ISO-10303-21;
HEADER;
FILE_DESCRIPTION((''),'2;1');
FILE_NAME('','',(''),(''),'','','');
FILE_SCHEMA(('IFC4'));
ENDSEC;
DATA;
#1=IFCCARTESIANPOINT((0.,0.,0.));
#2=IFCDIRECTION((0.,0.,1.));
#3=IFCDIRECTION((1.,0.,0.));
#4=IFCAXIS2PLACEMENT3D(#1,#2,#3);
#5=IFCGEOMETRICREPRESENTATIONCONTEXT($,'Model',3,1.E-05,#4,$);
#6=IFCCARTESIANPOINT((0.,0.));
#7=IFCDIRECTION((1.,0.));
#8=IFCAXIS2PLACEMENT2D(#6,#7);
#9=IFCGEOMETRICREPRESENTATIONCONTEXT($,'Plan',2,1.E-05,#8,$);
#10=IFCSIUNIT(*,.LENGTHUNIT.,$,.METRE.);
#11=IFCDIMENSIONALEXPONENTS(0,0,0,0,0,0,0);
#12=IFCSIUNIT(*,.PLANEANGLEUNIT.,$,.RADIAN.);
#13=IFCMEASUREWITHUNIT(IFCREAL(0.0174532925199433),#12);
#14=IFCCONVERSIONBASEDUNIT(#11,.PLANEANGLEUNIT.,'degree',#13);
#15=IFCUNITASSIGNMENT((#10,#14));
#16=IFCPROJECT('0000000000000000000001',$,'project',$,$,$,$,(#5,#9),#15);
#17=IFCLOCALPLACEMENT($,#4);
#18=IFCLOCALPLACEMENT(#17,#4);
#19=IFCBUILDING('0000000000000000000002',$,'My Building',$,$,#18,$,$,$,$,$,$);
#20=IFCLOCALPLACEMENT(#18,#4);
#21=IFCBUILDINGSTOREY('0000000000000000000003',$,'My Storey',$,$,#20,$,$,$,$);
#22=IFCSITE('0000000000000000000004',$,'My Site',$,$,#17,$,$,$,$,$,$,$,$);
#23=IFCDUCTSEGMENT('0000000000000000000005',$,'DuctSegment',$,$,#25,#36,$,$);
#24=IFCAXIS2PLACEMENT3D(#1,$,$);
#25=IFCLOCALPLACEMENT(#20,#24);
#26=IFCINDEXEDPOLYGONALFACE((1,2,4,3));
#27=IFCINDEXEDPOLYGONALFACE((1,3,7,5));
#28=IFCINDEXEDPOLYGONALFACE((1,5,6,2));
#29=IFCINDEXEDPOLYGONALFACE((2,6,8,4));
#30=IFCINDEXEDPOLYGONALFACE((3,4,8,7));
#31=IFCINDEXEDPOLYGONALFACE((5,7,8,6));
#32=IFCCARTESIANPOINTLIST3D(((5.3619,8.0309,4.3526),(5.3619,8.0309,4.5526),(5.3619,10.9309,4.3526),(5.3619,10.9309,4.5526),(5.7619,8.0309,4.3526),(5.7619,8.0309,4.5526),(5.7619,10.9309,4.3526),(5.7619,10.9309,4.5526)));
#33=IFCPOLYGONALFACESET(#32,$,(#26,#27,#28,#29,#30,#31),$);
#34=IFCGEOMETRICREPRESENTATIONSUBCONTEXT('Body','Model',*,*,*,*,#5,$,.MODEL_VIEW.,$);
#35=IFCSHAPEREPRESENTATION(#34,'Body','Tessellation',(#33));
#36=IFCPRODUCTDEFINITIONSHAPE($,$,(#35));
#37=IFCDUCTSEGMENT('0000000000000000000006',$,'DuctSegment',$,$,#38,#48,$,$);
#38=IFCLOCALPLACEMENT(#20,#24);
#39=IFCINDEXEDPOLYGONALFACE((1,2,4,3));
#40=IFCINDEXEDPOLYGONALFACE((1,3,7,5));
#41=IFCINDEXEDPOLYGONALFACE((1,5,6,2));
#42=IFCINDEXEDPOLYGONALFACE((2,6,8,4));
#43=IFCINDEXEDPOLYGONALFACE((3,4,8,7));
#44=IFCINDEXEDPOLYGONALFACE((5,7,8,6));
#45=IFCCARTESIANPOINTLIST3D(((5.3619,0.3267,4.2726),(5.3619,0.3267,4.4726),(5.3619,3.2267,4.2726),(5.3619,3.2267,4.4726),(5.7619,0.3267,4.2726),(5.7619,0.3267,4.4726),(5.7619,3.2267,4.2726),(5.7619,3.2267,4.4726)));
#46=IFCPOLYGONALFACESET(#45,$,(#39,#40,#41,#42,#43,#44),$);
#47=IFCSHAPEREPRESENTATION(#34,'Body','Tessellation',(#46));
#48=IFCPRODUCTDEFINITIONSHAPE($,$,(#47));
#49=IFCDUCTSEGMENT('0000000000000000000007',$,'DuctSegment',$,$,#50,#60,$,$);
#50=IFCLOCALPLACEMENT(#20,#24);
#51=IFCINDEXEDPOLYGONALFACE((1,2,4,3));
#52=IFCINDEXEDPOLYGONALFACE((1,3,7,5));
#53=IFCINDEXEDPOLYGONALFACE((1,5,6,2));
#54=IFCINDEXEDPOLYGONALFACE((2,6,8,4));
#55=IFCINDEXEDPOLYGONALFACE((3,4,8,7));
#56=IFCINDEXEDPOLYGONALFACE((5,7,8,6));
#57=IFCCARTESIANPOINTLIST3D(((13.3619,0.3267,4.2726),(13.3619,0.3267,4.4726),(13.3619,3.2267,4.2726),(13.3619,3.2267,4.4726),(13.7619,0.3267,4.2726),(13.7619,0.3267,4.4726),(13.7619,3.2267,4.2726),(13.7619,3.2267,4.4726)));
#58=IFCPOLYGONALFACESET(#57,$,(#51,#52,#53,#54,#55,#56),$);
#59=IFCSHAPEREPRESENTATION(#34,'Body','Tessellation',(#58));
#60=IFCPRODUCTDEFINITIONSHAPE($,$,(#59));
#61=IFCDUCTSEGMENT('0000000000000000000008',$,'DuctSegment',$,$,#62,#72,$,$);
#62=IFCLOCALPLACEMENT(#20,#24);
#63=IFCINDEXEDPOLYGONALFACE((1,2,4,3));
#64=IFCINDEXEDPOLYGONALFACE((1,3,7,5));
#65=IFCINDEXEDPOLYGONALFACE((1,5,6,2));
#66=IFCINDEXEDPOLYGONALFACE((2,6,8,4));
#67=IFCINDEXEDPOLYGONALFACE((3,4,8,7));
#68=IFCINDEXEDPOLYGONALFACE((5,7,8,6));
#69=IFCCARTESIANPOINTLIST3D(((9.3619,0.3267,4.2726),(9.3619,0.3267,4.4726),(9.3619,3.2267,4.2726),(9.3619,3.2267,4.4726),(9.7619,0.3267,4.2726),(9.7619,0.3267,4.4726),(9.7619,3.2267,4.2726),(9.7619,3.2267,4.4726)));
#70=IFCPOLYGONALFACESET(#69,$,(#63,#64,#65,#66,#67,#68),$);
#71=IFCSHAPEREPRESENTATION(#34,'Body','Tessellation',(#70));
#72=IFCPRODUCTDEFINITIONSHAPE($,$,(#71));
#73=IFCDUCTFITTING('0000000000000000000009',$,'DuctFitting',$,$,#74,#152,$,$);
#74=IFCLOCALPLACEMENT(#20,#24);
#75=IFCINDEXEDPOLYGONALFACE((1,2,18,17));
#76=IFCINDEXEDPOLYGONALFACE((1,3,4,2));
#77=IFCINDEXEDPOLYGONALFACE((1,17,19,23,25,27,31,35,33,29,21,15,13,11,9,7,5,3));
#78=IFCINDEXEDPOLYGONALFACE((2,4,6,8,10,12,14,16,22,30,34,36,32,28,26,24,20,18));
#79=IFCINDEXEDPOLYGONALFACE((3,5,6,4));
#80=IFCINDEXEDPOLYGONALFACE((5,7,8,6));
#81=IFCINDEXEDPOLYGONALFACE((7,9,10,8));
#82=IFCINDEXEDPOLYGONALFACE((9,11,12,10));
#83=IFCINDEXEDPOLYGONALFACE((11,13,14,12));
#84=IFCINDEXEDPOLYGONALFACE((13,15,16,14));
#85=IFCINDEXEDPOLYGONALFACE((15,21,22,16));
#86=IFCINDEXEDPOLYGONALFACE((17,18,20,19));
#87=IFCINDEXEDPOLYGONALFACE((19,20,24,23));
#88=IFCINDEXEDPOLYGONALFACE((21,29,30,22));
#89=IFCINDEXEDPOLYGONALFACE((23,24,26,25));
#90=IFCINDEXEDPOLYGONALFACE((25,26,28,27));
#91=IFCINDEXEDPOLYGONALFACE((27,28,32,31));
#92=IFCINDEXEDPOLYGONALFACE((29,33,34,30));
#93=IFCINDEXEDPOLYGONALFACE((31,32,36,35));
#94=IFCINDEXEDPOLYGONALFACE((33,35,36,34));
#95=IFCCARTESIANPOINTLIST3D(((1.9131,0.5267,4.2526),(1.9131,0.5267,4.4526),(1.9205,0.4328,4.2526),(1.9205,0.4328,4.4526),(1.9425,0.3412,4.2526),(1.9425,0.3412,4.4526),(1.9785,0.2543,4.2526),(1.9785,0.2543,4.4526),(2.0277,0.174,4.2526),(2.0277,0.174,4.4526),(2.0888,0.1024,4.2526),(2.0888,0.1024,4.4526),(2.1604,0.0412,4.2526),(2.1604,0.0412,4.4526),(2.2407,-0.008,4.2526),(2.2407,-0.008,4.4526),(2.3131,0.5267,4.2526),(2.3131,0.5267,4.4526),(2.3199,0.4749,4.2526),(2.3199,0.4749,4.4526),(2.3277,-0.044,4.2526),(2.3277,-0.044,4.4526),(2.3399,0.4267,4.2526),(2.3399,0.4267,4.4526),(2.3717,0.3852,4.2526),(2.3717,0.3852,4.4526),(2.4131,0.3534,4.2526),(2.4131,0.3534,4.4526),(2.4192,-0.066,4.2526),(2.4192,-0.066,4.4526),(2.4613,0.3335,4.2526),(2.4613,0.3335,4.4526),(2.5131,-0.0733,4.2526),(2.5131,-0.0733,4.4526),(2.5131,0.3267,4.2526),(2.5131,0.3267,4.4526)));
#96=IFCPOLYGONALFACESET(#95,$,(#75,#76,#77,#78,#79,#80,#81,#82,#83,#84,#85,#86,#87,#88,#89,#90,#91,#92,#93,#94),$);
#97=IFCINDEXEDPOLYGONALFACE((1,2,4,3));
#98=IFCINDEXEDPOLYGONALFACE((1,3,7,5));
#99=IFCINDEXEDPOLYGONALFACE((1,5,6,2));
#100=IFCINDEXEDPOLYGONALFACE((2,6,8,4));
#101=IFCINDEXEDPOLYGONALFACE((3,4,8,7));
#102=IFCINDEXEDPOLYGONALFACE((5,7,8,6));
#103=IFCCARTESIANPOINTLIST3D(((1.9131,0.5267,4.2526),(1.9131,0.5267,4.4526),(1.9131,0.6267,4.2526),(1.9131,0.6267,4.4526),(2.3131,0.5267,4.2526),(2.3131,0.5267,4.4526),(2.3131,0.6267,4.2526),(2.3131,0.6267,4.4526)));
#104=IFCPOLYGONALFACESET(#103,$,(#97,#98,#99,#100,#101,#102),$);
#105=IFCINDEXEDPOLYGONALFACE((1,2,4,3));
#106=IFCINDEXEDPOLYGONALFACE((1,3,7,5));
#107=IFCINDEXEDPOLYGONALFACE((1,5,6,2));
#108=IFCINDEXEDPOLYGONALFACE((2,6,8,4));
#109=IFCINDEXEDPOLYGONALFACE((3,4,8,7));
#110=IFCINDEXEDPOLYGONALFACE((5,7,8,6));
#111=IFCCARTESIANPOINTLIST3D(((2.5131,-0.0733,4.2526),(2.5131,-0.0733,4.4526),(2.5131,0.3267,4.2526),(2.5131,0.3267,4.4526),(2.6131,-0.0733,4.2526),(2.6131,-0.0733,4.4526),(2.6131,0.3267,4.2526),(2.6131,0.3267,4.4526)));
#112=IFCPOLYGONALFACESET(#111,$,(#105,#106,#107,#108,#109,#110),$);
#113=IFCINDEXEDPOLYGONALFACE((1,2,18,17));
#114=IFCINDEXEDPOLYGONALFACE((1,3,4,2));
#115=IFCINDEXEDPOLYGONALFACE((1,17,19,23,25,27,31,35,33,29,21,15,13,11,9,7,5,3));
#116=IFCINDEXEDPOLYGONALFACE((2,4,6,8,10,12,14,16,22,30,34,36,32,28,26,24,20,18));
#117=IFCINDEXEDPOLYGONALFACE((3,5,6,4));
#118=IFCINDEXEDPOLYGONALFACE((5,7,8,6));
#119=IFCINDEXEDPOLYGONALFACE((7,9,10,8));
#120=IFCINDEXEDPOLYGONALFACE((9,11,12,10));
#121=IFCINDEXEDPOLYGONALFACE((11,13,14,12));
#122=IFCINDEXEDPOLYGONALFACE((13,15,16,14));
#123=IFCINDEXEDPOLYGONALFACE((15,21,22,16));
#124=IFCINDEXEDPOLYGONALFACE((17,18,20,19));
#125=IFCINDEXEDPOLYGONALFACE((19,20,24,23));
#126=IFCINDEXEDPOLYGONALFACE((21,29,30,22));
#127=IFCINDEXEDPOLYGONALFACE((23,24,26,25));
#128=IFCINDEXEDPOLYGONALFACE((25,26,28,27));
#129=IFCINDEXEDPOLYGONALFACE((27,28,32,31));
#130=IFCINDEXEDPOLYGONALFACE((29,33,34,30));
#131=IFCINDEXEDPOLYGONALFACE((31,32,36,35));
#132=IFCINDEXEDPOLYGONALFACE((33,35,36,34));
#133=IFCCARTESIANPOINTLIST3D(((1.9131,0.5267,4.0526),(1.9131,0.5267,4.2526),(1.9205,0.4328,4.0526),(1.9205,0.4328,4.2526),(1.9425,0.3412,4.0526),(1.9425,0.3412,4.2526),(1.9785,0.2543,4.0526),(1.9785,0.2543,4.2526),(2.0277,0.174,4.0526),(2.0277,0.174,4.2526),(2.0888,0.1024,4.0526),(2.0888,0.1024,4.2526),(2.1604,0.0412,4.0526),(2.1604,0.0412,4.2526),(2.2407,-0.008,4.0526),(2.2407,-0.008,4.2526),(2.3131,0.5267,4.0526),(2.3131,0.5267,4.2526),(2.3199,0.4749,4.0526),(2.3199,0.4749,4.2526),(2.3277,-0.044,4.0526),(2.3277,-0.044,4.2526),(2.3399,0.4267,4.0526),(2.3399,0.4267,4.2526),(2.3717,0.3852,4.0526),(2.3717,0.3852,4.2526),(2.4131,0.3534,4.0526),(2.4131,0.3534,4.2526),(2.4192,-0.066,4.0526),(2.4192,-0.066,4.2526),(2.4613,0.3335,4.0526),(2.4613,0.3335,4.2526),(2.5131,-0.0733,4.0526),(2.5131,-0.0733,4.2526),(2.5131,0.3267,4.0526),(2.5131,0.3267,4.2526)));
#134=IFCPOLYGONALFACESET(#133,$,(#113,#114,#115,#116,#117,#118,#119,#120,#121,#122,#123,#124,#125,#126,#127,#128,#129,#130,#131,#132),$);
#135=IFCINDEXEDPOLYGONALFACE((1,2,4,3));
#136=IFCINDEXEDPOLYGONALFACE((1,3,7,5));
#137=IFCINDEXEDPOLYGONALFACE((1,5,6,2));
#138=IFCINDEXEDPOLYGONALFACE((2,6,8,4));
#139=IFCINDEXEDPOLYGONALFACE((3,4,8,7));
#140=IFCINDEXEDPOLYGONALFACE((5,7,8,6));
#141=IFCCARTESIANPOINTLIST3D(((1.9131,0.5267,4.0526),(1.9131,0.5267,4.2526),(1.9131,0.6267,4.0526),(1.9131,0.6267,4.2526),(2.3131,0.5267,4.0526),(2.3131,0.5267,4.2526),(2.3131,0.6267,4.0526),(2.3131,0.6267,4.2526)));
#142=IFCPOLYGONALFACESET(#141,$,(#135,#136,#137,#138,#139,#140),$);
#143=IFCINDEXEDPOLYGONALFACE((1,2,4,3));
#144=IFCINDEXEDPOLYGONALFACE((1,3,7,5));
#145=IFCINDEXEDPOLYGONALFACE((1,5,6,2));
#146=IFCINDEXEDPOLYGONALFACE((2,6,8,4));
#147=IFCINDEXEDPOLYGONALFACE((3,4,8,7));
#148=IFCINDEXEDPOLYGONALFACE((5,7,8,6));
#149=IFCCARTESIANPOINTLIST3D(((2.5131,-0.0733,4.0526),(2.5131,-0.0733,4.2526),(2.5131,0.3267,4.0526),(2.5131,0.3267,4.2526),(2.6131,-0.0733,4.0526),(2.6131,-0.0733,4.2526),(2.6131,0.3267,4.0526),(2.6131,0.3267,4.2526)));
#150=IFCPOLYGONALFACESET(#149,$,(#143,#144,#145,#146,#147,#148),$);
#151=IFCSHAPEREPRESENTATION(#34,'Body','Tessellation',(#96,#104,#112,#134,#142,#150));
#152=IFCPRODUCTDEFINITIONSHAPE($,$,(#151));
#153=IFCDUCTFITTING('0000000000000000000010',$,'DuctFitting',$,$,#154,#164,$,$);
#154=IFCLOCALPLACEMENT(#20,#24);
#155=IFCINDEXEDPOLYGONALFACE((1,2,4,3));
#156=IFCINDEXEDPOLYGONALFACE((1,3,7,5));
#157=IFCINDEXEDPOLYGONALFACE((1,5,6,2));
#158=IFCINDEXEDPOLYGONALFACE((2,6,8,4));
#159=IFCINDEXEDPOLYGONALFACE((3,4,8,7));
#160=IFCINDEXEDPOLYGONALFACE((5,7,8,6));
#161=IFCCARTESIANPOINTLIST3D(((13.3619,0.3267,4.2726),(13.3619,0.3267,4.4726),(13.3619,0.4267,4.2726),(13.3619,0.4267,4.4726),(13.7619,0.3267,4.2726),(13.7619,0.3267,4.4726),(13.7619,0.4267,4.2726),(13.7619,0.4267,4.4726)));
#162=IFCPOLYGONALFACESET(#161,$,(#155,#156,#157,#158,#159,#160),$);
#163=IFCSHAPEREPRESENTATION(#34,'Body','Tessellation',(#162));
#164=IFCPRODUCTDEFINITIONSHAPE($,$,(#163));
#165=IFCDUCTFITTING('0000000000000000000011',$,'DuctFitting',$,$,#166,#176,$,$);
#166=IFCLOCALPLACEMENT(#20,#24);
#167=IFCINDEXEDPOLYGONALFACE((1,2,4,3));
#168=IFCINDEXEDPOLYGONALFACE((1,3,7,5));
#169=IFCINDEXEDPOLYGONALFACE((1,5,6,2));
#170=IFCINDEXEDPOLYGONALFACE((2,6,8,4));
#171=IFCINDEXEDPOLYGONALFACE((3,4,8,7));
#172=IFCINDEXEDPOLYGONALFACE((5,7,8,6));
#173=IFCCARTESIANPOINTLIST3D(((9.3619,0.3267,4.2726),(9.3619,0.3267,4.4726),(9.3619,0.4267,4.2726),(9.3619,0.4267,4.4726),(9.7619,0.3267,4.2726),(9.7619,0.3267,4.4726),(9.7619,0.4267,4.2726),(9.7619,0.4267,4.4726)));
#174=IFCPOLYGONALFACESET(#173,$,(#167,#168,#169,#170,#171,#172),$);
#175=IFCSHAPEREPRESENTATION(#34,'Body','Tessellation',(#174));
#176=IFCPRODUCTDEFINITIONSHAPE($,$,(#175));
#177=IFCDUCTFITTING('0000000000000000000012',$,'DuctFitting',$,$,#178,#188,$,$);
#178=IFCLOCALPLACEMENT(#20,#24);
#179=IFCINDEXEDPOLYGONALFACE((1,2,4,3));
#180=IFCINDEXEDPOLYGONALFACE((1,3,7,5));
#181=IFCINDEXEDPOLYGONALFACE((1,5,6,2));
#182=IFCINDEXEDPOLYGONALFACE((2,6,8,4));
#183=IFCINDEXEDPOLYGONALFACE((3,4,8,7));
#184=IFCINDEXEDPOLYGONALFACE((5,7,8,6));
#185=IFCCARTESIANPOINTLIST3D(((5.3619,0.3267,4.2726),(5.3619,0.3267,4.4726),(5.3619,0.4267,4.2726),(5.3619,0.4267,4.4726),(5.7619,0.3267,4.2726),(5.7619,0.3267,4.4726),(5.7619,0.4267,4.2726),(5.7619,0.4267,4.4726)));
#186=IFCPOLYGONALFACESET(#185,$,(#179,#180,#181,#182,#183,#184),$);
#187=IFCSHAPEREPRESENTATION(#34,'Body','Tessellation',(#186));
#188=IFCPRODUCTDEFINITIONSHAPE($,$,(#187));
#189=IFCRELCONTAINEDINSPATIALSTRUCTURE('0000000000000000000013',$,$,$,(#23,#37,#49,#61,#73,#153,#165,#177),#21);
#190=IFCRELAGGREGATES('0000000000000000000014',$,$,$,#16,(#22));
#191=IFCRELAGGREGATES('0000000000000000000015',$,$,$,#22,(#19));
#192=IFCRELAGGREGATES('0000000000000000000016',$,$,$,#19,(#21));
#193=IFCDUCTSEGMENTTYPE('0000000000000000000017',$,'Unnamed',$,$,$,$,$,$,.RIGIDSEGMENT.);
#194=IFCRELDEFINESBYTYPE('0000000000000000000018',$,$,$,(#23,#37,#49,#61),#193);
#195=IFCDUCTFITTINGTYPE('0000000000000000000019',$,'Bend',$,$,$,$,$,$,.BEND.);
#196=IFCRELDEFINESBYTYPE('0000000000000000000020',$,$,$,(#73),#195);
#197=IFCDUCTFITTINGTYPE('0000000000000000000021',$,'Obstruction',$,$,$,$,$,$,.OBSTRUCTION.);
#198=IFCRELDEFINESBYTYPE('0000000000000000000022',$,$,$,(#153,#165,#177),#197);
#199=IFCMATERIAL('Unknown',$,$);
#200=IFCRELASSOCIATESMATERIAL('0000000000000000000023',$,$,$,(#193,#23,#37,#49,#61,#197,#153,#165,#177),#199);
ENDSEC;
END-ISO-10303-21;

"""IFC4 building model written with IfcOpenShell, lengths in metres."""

from ifc_helpers import new_model, entity, si_unit, converted_unit, frame, origin_with_axes, origin_2d_with_axis, place, context, subcontext, project, spatial, line, arc, indexed_curve, rectangle, outline, extrude, source, transform, mapped, material, material_profile, profile_set, profile_usage, type_object, type_shapes, element, save


model = new_model("IFC4")

# Units and contexts
model_context = context("Model", 3, precision=1e-05, world=origin_with_axes())
plan_context = context("Plan", 2, precision=1e-05, world=origin_2d_with_axis())
body_context_1 = subcontext(model_context, "Body", "Model", "MODEL_VIEW")
ifc_project = project(units=[si_unit("LENGTHUNIT", "METRE"), converted_unit("PLANEANGLEUNIT", "degree", entity("IfcReal", 0.0174532925199433), si_unit("PLANEANGLEUNIT", "RADIAN"), dimensions=[0, 0, 0, 0, 0, 0, 0])], contexts=[model_context, plan_context])

# Site, building, storey
site_placement = place(None, origin_with_axes())
site = spatial("IfcSite", under=ifc_project, at=site_placement, Name="My Site")
building_placement = place(site_placement, origin_with_axes())
building = spatial("IfcBuilding", under=site, at=building_placement, Name="My Building")
storey_placement = place(building_placement, origin_with_axes())
storey = spatial("IfcBuildingStorey", under=building, at=storey_placement, Name="My Storey")

# Shared definitions
ifc_material = material(Name="Unknown")

# Duct segments
ifc_material_profile_1 = material_profile(ifc_material, rectangle(XDim=0.4, YDim=0.2))
ifc_profile_set_1 = profile_set([ifc_material_profile_1])
duct_segment_type = type_object("IfcDuctSegmentType", Name="Unnamed", PredefinedType="RIGIDSEGMENT", material=ifc_profile_set_1)
ifc_profile_usage_1 = profile_usage(ifc_profile_set_1, cardinal=5)
duct_segment_1_placement = place(storey_placement, frame((5.5619, 10.9309, 4.4526), z_axis=(0.0, -1.0, 0.0), x_axis=(1.0, 0.0, 0.0)))
element("IfcDuctSegment", 1, at=duct_segment_1_placement, inside=storey, type_object=duct_segment_type, material=ifc_profile_usage_1, Name="DuctSegment", context=body_context_1, shape_type="SweptSolid", body=[
    extrude(rectangle(XDim=0.4, YDim=0.2), origin_with_axes(), (0.0, 0.0, 1.0), 2.9),
])
ifc_profile_usage_2 = profile_usage(ifc_profile_set_1, cardinal=5)
duct_segment_2_placement = place(storey_placement, frame((5.5619, 0.3267, 4.3726), z_axis=(0.0, 1.0, 0.0), x_axis=(-1.0, 0.0, 0.0)))
element("IfcDuctSegment", 2, at=duct_segment_2_placement, inside=storey, type_object=duct_segment_type, material=ifc_profile_usage_2, Name="DuctSegment", context=body_context_1, shape_type="SweptSolid", body=[
    extrude(rectangle(XDim=0.4, YDim=0.2), origin_with_axes(), (0.0, 0.0, 1.0), 2.9),
])
ifc_profile_usage_3 = profile_usage(ifc_profile_set_1, cardinal=5)
duct_segment_3_placement = place(storey_placement, frame((13.5619, 0.3267, 4.3726), z_axis=(0.0, 1.0, 0.0), x_axis=(-1.0, 0.0, 0.0)))
element("IfcDuctSegment", 3, at=duct_segment_3_placement, inside=storey, type_object=duct_segment_type, material=ifc_profile_usage_3, Name="DuctSegment", context=body_context_1, shape_type="SweptSolid", body=[
    extrude(rectangle(XDim=0.4, YDim=0.2), origin_with_axes(), (0.0, 0.0, 1.0), 2.9),
])
ifc_profile_usage_4 = profile_usage(ifc_profile_set_1, cardinal=5)
duct_segment_4_placement = place(storey_placement, frame((9.5619, 0.3267, 4.3726), z_axis=(0.0, 1.0, 0.0), x_axis=(-1.0, 0.0, 0.0)))
element("IfcDuctSegment", 4, at=duct_segment_4_placement, inside=storey, type_object=duct_segment_type, material=ifc_profile_usage_4, Name="DuctSegment", context=body_context_1, shape_type="SweptSolid", body=[
    extrude(rectangle(XDim=0.4, YDim=0.2), origin_with_axes(), (0.0, 0.0, 1.0), 2.9),
])

# Duct fittings
duct_fitting_type_1 = type_object("IfcDuctFittingType", Name="Bend", PredefinedType="BEND")
shared_shape_1 = source(origin_with_axes(), body_context_1, "Body", "SweptSolid", [
    extrude(outline(indexed_curve([(0.2, 0.0), (0.2586, 0.1414), (0.4, 0.2), (0.4, 0.6), (-0.0243, 0.4243), (-0.2, 0.0)], segments=[arc(1, 2, 3), line(3, 4), arc(4, 5, 6), line(6, 1)])), frame((0.0, -0.1, 0.1), z_axis=(0.0, -1.0, 0.0), x_axis=(1.0, 0.0, 0.0)), (0.0, 0.0, -1.0), 0.2),
    extrude(rectangle(XDim=0.4, YDim=0.2), origin_with_axes(), (0.0, 0.0, 1.0), 0.1),
    extrude(rectangle(XDim=0.4, YDim=0.2), frame((0.4, 0.0, 0.5), z_axis=(1.0, 0.0, 0.0), x_axis=(0.0, 0.0, 1.0)), (0.0, 0.0, 1.0), 0.1),
    extrude(outline(indexed_curve([(0.2, 0.0), (0.2586, 0.1414), (0.4, 0.2), (0.4, 0.6), (-0.0243, 0.4243), (-0.2, 0.0)], segments=[arc(1, 2, 3), line(3, 4), arc(4, 5, 6), line(6, 1)])), frame((0.0, -0.3, 0.1), z_axis=(0.0, -1.0, 0.0), x_axis=(1.0, 0.0, 0.0)), (0.0, 0.0, -1.0), 0.2),
    extrude(rectangle(XDim=0.4, YDim=0.2), frame((0.0, -0.2, 0.0), z_axis=(0.0, 0.0, 1.0), x_axis=(1.0, 0.0, 0.0)), (0.0, 0.0, 1.0), 0.1),
    extrude(rectangle(XDim=0.4, YDim=0.2), frame((0.4, -0.2, 0.5), z_axis=(1.0, 0.0, 0.0), x_axis=(0.0, 0.0, 1.0)), (0.0, 0.0, 1.0), 0.1),
])
type_shapes(duct_fitting_type_1, [shared_shape_1])
duct_fitting_1_placement = place(storey_placement, frame((2.1131, 0.6267, 4.3526), z_axis=(0.0, -1.0, 0.0), x_axis=(1.0, 0.0, 0.0)))
element("IfcDuctFitting", 5, at=duct_fitting_1_placement, inside=storey, type_object=duct_fitting_type_1, Name="DuctFitting", context=body_context_1, shape_type="MappedRepresentation", body=[
    mapped(shared_shape_1, transform((0.0, 0.0, 0.0), x_axis=(1.0, 0.0, 0.0), y_axis=(0.0, 1.0, 0.0), z_axis=(0.0, 0.0, 1.0), scale=1.0)),
])
ifc_material_profile_2 = material_profile(ifc_material, rectangle(XDim=0.4, YDim=0.2))
ifc_profile_set_2 = profile_set([ifc_material_profile_2])
ifc_profile_usage_5 = profile_usage(ifc_profile_set_2, cardinal=5)
duct_fitting_type_2 = type_object("IfcDuctFittingType", Name="Obstruction", PredefinedType="OBSTRUCTION", material=ifc_profile_set_2)
duct_fitting_2_placement = place(storey_placement, frame((13.5619, 0.3267, 4.3726), z_axis=(0.0, 1.0, 0.0), x_axis=(-1.0, 0.0, 0.0)))
element("IfcDuctFitting", 6, at=duct_fitting_2_placement, inside=storey, type_object=duct_fitting_type_2, material=ifc_profile_usage_5, Name="DuctFitting", context=body_context_1, shape_type="SweptSolid", body=[
    extrude(rectangle(XDim=0.4, YDim=0.2), origin_with_axes(), (0.0, 0.0, 1.0), 0.1),
])
ifc_profile_usage_6 = profile_usage(ifc_profile_set_2, cardinal=5)
duct_fitting_3_placement = place(storey_placement, frame((9.5619, 0.3267, 4.3726), z_axis=(0.0, 1.0, 0.0), x_axis=(-1.0, 0.0, 0.0)))
element("IfcDuctFitting", 7, at=duct_fitting_3_placement, inside=storey, type_object=duct_fitting_type_2, material=ifc_profile_usage_6, Name="DuctFitting", context=body_context_1, shape_type="SweptSolid", body=[
    extrude(rectangle(XDim=0.4, YDim=0.2), origin_with_axes(), (0.0, 0.0, 1.0), 0.1),
])
ifc_profile_usage_7 = profile_usage(ifc_profile_set_2, cardinal=5)
duct_fitting_4_placement = place(storey_placement, frame((5.5619, 0.3267, 4.3726), z_axis=(0.0, 1.0, 0.0), x_axis=(-1.0, 0.0, 0.0)))
element("IfcDuctFitting", 8, at=duct_fitting_4_placement, inside=storey, type_object=duct_fitting_type_2, material=ifc_profile_usage_7, Name="DuctFitting", context=body_context_1, shape_type="SweptSolid", body=[
    extrude(rectangle(XDim=0.4, YDim=0.2), origin_with_axes(), (0.0, 0.0, 1.0), 0.1),
])

save(model, "model.ifc")
